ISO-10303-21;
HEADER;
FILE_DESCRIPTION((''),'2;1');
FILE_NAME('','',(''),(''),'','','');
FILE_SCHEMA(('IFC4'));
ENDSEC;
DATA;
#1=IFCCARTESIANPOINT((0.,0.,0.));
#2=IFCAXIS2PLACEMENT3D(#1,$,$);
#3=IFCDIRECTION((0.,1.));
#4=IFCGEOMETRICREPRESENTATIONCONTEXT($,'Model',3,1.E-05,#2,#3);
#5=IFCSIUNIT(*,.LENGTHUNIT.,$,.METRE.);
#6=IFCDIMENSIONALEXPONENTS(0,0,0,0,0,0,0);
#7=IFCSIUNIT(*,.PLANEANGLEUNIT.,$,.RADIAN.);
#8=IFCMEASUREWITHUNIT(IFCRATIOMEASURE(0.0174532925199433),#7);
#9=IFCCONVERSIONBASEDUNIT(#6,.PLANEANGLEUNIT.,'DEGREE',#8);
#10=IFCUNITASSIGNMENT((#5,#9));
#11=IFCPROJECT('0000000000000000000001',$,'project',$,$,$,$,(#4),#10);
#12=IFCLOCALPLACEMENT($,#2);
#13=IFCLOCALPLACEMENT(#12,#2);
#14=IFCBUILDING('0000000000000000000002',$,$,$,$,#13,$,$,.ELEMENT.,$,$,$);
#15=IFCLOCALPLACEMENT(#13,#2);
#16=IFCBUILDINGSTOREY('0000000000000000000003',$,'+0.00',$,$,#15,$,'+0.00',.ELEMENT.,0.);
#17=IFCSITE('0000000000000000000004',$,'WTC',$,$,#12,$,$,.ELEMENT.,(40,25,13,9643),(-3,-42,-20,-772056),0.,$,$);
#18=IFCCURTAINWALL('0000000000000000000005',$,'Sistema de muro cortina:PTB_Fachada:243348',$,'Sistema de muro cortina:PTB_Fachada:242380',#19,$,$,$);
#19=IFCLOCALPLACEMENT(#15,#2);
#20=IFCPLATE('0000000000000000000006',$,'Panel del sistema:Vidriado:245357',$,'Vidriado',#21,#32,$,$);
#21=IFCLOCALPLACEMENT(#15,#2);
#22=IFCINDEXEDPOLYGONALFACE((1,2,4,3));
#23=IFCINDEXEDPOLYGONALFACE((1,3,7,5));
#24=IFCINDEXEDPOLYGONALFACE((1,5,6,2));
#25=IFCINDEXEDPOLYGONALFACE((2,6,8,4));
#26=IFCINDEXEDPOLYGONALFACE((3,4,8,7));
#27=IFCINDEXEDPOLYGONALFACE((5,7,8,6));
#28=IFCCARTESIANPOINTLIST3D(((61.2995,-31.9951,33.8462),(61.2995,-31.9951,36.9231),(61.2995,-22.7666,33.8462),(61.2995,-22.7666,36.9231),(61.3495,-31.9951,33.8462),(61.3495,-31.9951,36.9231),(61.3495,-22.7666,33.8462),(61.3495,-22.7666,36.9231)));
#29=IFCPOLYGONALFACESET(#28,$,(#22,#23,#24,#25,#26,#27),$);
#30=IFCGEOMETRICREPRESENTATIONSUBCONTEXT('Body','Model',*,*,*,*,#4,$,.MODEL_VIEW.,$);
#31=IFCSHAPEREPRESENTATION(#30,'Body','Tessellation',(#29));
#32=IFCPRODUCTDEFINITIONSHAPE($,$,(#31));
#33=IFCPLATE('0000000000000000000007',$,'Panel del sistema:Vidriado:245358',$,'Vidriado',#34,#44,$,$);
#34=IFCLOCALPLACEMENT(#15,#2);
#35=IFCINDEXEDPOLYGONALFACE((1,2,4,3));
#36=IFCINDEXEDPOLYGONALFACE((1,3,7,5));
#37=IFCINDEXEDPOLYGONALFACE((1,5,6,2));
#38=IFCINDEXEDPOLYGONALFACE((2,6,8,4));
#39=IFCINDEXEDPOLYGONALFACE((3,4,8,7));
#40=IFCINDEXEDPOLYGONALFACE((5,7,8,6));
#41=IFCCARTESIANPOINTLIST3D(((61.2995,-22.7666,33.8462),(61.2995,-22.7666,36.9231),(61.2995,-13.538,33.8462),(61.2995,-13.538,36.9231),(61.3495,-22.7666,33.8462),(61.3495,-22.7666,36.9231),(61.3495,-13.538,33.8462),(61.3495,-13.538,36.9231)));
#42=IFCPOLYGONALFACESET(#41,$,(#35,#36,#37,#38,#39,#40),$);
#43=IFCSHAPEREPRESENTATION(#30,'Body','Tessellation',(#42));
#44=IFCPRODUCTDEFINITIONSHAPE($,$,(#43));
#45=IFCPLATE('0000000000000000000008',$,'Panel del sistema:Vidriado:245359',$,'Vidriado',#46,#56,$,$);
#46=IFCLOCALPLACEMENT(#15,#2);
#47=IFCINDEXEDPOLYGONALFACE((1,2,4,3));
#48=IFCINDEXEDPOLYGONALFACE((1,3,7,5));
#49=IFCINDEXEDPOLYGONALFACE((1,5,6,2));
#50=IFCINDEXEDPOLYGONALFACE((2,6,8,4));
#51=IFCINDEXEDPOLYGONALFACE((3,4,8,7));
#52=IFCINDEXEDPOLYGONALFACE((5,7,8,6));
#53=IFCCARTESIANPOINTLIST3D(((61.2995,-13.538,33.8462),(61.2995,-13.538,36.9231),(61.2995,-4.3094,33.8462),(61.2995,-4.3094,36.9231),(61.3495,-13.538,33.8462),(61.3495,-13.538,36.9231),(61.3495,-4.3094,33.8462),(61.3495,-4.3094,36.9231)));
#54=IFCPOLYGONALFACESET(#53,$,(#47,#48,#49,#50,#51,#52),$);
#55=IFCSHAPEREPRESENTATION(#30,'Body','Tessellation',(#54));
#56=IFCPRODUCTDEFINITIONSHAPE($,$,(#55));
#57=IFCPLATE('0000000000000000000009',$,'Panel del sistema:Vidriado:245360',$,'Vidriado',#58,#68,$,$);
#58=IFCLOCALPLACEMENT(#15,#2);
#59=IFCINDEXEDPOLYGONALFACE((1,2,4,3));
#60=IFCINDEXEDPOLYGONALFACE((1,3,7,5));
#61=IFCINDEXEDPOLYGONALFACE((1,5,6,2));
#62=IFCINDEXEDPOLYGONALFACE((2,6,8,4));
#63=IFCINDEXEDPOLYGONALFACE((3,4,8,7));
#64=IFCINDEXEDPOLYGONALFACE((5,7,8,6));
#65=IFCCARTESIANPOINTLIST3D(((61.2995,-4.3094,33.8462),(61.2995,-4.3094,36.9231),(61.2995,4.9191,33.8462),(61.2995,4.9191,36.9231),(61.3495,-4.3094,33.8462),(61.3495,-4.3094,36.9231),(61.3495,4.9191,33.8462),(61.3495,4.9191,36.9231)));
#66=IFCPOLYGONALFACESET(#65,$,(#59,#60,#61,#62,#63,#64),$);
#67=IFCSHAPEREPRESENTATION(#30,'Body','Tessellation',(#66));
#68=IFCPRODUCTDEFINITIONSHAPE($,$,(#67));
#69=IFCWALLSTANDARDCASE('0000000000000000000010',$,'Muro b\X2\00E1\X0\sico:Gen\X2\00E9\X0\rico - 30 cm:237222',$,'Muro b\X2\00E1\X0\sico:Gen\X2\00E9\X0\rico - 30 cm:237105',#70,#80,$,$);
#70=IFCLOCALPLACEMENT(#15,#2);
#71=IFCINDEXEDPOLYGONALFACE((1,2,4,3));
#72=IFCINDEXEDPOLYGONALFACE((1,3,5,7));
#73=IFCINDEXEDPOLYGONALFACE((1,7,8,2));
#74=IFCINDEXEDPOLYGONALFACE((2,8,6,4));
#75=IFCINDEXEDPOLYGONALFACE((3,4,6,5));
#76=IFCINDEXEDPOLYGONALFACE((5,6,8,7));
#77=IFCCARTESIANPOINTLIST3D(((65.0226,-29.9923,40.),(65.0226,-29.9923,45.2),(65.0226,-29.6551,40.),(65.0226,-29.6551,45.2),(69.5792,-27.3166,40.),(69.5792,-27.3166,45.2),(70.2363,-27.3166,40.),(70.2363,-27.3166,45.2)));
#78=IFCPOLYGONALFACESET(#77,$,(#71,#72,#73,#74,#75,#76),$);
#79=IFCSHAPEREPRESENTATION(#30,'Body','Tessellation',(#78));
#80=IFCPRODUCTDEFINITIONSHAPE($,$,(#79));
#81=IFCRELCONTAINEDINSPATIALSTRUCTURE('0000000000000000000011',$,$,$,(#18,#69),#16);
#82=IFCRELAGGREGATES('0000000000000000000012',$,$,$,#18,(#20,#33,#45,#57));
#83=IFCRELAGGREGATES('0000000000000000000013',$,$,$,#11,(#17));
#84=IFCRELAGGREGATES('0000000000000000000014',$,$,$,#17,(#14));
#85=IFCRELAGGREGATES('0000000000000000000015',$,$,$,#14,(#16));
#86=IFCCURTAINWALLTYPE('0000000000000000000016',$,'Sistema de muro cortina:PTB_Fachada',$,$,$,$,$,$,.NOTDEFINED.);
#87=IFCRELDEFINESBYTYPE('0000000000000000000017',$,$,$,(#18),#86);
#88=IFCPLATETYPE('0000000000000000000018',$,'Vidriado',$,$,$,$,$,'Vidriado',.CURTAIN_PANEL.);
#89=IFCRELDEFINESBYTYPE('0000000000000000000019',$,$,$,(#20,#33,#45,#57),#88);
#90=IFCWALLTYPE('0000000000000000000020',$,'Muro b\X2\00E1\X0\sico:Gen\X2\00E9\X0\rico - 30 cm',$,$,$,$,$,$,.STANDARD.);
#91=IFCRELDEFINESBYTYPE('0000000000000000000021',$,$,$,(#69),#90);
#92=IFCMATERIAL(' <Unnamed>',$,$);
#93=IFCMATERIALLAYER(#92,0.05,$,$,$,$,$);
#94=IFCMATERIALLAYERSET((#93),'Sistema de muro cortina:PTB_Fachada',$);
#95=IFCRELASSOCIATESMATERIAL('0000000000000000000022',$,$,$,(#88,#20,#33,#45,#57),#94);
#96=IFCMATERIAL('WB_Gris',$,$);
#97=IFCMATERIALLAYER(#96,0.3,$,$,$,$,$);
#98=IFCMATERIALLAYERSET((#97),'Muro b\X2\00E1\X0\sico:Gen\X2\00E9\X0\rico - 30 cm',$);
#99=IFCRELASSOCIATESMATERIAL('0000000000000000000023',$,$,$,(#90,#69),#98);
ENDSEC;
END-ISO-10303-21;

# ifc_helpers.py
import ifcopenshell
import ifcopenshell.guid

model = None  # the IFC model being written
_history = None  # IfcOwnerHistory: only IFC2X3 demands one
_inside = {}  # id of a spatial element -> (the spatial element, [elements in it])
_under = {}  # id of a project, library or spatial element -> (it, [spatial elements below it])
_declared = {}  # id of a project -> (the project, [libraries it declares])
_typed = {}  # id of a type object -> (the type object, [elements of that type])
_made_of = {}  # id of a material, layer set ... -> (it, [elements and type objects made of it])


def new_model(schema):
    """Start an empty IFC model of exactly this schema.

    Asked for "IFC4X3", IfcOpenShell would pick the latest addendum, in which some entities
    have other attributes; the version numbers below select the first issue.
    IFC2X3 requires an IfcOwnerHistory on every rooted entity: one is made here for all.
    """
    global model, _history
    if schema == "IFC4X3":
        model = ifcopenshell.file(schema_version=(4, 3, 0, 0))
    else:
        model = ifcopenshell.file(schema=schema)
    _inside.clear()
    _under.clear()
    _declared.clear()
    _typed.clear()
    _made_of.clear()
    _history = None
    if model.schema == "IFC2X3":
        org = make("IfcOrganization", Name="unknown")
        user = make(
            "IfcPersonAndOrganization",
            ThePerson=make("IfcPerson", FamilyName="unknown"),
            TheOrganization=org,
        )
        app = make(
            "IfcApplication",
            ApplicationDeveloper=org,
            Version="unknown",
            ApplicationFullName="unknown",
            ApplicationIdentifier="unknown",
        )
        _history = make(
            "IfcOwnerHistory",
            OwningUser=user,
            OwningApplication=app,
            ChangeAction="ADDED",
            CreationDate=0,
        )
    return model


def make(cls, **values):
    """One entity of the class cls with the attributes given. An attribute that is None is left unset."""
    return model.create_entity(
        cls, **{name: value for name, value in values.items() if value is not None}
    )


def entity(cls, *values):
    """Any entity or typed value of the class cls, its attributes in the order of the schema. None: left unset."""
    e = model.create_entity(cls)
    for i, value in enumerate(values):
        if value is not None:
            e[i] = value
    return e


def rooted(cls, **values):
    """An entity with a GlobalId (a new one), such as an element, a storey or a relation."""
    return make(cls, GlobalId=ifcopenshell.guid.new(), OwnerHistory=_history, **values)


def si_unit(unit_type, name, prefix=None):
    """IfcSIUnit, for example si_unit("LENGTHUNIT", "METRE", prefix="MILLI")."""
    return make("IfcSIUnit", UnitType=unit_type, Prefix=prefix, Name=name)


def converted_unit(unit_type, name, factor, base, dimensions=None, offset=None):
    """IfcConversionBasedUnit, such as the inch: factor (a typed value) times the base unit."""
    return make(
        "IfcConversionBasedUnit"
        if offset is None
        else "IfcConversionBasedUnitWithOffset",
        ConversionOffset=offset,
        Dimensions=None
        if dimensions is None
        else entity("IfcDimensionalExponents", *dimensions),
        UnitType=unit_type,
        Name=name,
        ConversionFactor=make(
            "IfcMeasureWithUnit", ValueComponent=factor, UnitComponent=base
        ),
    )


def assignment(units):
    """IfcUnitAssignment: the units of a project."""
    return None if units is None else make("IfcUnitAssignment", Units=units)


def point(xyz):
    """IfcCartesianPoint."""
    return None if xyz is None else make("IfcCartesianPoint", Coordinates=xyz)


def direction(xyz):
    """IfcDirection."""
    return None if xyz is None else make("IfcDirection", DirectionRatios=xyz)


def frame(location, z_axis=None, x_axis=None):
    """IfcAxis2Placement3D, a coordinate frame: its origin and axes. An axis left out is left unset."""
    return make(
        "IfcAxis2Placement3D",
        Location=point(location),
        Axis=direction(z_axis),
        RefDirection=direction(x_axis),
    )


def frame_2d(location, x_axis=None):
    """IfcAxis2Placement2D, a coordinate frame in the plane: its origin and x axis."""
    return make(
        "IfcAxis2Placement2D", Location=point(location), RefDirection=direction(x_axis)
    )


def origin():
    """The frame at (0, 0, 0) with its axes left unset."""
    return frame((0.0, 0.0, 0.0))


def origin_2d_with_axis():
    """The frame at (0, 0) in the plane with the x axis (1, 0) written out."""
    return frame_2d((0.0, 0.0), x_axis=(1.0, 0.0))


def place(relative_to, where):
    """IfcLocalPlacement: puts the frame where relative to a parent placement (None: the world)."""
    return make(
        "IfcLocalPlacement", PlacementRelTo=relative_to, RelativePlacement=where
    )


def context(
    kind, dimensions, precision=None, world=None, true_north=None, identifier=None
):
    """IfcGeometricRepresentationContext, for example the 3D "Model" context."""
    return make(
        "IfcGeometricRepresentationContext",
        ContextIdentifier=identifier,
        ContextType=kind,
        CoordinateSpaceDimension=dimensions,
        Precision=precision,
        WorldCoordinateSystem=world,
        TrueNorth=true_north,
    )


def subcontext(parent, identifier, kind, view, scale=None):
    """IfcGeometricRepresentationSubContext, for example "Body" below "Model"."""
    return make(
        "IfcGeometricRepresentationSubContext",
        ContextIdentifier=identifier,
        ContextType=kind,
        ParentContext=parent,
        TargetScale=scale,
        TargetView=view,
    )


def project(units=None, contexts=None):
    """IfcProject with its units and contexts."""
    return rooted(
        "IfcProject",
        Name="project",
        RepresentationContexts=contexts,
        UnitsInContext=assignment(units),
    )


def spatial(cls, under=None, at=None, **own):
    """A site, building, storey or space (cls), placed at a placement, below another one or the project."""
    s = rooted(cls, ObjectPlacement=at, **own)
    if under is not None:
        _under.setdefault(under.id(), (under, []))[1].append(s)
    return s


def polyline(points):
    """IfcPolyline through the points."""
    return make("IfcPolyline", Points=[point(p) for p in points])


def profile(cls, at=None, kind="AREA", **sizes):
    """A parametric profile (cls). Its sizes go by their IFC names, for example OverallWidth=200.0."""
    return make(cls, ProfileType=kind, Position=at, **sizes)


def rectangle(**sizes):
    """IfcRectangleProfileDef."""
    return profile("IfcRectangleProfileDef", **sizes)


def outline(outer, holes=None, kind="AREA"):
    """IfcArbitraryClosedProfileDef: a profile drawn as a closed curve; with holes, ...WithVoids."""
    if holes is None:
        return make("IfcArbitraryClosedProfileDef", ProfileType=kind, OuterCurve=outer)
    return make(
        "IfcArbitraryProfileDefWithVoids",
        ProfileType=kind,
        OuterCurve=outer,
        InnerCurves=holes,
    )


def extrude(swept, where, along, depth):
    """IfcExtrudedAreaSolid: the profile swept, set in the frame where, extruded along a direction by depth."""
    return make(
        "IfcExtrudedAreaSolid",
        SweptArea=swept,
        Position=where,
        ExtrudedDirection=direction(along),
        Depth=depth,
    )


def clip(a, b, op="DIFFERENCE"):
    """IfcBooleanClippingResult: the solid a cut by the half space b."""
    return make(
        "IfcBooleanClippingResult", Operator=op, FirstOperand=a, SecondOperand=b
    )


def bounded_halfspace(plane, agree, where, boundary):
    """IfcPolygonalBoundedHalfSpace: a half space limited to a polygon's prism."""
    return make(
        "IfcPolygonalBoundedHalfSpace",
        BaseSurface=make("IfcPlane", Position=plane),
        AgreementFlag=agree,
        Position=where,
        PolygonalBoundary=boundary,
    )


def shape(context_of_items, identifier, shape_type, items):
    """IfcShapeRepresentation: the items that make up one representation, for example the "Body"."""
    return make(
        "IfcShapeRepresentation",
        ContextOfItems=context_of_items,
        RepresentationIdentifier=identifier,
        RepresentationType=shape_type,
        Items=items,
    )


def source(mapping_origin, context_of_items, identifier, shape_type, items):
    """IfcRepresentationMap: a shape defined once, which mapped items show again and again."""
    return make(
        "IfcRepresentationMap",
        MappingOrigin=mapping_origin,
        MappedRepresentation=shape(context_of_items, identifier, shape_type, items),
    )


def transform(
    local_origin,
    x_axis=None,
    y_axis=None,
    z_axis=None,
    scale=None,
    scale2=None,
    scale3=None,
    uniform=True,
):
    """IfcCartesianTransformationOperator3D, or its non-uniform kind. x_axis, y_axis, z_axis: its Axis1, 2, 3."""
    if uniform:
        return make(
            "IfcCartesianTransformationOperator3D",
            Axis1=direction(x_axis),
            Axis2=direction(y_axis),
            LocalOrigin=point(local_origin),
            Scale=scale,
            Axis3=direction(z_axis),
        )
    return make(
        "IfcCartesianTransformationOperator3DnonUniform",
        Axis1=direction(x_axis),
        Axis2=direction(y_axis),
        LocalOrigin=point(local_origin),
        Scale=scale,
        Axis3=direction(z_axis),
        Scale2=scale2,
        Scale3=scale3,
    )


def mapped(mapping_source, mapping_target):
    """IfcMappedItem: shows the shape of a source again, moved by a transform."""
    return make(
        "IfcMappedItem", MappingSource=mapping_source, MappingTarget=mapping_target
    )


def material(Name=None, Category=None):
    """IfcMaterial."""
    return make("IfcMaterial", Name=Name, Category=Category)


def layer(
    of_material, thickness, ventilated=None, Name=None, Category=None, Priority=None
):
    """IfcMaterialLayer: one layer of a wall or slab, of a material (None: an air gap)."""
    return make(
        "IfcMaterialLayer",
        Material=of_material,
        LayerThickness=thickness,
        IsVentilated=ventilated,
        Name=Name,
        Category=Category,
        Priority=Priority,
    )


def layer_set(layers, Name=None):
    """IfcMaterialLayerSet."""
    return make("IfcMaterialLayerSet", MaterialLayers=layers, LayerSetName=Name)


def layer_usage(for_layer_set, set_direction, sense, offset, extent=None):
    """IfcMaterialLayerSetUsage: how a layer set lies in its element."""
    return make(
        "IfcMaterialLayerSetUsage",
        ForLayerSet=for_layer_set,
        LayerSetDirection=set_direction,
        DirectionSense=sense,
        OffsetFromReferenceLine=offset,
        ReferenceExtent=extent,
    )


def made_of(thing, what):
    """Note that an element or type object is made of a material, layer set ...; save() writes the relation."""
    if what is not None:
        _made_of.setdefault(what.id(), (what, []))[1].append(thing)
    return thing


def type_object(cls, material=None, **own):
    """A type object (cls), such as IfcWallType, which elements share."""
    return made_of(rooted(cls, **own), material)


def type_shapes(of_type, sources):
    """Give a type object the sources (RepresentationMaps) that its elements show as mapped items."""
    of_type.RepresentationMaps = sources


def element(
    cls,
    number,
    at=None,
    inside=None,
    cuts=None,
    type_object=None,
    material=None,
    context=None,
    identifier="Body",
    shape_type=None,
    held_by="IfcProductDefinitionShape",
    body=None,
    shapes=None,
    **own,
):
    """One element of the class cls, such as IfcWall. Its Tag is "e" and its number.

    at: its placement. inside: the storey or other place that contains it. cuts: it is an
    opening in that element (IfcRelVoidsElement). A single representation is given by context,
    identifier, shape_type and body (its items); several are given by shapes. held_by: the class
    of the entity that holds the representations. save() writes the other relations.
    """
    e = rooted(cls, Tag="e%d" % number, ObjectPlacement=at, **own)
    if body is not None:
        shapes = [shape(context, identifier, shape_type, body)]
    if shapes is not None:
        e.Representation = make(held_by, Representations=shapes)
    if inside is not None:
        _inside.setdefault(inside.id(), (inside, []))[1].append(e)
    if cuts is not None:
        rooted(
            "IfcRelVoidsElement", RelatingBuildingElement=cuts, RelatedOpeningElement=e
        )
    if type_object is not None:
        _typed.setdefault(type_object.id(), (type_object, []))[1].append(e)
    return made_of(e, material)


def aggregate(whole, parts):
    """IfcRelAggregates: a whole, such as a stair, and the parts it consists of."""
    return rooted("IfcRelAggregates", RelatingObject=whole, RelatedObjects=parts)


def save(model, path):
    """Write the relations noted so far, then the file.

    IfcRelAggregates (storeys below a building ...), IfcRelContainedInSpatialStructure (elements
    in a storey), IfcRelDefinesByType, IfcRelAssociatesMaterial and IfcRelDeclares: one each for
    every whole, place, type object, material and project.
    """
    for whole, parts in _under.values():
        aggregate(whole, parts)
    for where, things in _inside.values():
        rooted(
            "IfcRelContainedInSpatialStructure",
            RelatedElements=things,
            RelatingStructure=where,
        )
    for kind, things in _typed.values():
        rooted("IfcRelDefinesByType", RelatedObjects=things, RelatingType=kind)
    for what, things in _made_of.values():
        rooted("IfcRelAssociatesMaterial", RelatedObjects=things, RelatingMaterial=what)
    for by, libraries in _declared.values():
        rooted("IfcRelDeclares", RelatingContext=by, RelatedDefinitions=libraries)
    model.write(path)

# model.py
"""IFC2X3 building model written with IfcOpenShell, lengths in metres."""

from ifc_helpers import new_model, entity, si_unit, converted_unit, direction, frame, origin, origin_2d_with_axis, place, context, subcontext, project, spatial, polyline, rectangle, outline, extrude, clip, bounded_halfspace, source, transform, mapped, material, layer, layer_set, layer_usage, type_object, type_shapes, element, aggregate, save


model = new_model("IFC2X3")

# Units and contexts
model_context = context("Model", 3, precision=1e-05, world=origin(), true_north=direction((0.0, 1.0)))
body_context = subcontext(model_context, "Body", "Model", "MODEL_VIEW")
ifc_project = project(units=[si_unit("LENGTHUNIT", "METRE"), converted_unit("PLANEANGLEUNIT", "DEGREE", entity("IfcRatioMeasure", 0.0174532925199433), si_unit("PLANEANGLEUNIT", "RADIAN"), dimensions=[0, 0, 0, 0, 0, 0, 0])], contexts=[model_context])

# Site, building, storey
site_placement = place(None, origin())
site = spatial("IfcSite", under=ifc_project, at=site_placement, Name="WTC", CompositionType="ELEMENT", RefLatitude=(40, 25, 13, 9643), RefLongitude=(-3, -42, -20, -772056), RefElevation=0.0)
building_placement = place(site_placement, origin())
building = spatial("IfcBuilding", under=site, at=building_placement, CompositionType="ELEMENT")
storey_placement = place(building_placement, origin())
storey = spatial("IfcBuildingStorey", under=building, at=storey_placement, Name="+0.00", LongName="+0.00", CompositionType="ELEMENT", Elevation=0.0)

# Curtain wall, plates
curtain_wall_type = type_object("IfcCurtainWallType", Name="Sistema de muro cortina:PTB_Fachada", PredefinedType="NOTDEFINED")
ifc_material_1 = material(Name=" <Unnamed>")
ifc_layer_1 = layer(ifc_material_1, 0.05)
ifc_layer_set_1 = layer_set([ifc_layer_1], Name="Sistema de muro cortina:PTB_Fachada")
curtain_wall_1_placement = place(storey_placement, origin())
curtain_wall_1 = element("IfcCurtainWall", 1, at=curtain_wall_1_placement, inside=storey, type_object=curtain_wall_type, Name="Sistema de muro cortina:PTB_Fachada:243348", ObjectType="Sistema de muro cortina:PTB_Fachada:242380")
plate_type_1 = type_object("IfcPlateType", Name="Vidriado", ElementType="Vidriado", PredefinedType="CURTAIN_PANEL", material=ifc_layer_set_1)
shared_shape_1 = source(origin(), body_context, "Body", "SweptSolid", [
    extrude(rectangle(XDim=0.05, YDim=9.2286, at=origin_2d_with_axis()), frame((0.0, 0.0, 0.0), z_axis=(0.0, 0.0, 1.0), x_axis=(0.0, 1.0, 0.0)), (0.0, 0.0, 1.0), 3.0769),
])
type_shapes(plate_type_1, [shared_shape_1])
ifc_layer_usage_1 = layer_usage(ifc_layer_set_1, "AXIS3", "POSITIVE", 0.0)
plate_1_placement = place(curtain_wall_1_placement, frame((61.3245, -27.3809, 33.8462), z_axis=(0.0, 0.0, 1.0), x_axis=(0.0, 1.0, 0.0)))
plate_1 = element("IfcPlate", 2, at=plate_1_placement, type_object=plate_type_1, material=ifc_layer_usage_1, Name="Panel del sistema:Vidriado:245357", ObjectType="Vidriado", context=body_context, shape_type="MappedRepresentation", body=[
    mapped(shared_shape_1, transform((0.0, 0.0, 0.0), scale=1.0)),
])
ifc_layer_usage_2 = layer_usage(ifc_layer_set_1, "AXIS3", "POSITIVE", 0.0)
plate_2_placement = place(curtain_wall_1_placement, frame((61.3245, -18.1523, 33.8462), z_axis=(0.0, 0.0, 1.0), x_axis=(0.0, 1.0, 0.0)))
plate_2 = element("IfcPlate", 3, at=plate_2_placement, type_object=plate_type_1, material=ifc_layer_usage_2, Name="Panel del sistema:Vidriado:245358", ObjectType="Vidriado", context=body_context, shape_type="MappedRepresentation", body=[
    mapped(shared_shape_1, transform((0.0, 0.0, 0.0), scale=1.0)),
])
ifc_layer_usage_3 = layer_usage(ifc_layer_set_1, "AXIS3", "POSITIVE", 0.0)
plate_3_placement = place(curtain_wall_1_placement, frame((61.3245, -8.9237, 33.8462), z_axis=(0.0, 0.0, 1.0), x_axis=(0.0, 1.0, 0.0)))
plate_3 = element("IfcPlate", 4, at=plate_3_placement, type_object=plate_type_1, material=ifc_layer_usage_3, Name="Panel del sistema:Vidriado:245359", ObjectType="Vidriado", context=body_context, shape_type="MappedRepresentation", body=[
    mapped(shared_shape_1, transform((0.0, 0.0, 0.0), scale=1.0)),
])
ifc_layer_usage_4 = layer_usage(ifc_layer_set_1, "AXIS3", "POSITIVE", 0.0)
plate_4_placement = place(curtain_wall_1_placement, frame((61.3245, 0.3049, 33.8462), z_axis=(0.0, 0.0, 1.0), x_axis=(0.0, 1.0, 0.0)))
plate_4 = element("IfcPlate", 5, at=plate_4_placement, type_object=plate_type_1, material=ifc_layer_usage_4, Name="Panel del sistema:Vidriado:245360", ObjectType="Vidriado", context=body_context, shape_type="MappedRepresentation", body=[
    mapped(shared_shape_1, transform((0.0, 0.0, 0.0), scale=1.0)),
])
aggregate(curtain_wall_1, [plate_1, plate_2, plate_3, plate_4])

# Wall
ifc_material_2 = material(Name="WB_Gris")
ifc_layer_2 = layer(ifc_material_2, 0.3)
ifc_layer_set_2 = layer_set([ifc_layer_2], Name="Muro básico:Genérico - 30 cm")
wall_type = type_object("IfcWallType", Name="Muro básico:Genérico - 30 cm", PredefinedType="STANDARD", material=ifc_layer_set_2)
ifc_layer_usage_5 = layer_usage(ifc_layer_set_2, "AXIS2", "POSITIVE", -0.15)
wall_1_placement = place(storey_placement, frame((64.9541, -29.8589, 40.0), z_axis=(0.0, 0.0, 1.0), x_axis=(0.889674, 0.456596, 0.0)))
element("IfcWallStandardCase", 6, at=wall_1_placement, inside=storey, type_object=wall_type, material=ifc_layer_usage_5, Name="Muro básico:Genérico - 30 cm:237222", ObjectType="Muro básico:Genérico - 30 cm:237105", context=body_context, shape_type="Clipping", body=[
    clip(extrude(outline(polyline([(5.8602, -0.15), (5.2757, 0.15), (0.4912, 0.15), (0.154, 0.15), (0.0, -0.15), (5.8602, -0.15)])), origin(), (0.0, 0.0, 1.0), 5.2), bounded_halfspace(frame((0.0, -0.15, 5.2), z_axis=(0.0, 0.0, 1.0), x_axis=(0.889674, -0.456596, 0.0)), False, frame((0.0, -0.15, 5.2), z_axis=(0.0, 0.0, 1.0), x_axis=(0.889674, -0.456596, 0.0)), polyline([(0.0, 0.0), (5.2137, 2.6757), (4.5566, 2.6757), (0.3, 0.4912), (0.0, 0.3372), (0.0, 0.0)]))),
])

save(model, "model.ifc")
